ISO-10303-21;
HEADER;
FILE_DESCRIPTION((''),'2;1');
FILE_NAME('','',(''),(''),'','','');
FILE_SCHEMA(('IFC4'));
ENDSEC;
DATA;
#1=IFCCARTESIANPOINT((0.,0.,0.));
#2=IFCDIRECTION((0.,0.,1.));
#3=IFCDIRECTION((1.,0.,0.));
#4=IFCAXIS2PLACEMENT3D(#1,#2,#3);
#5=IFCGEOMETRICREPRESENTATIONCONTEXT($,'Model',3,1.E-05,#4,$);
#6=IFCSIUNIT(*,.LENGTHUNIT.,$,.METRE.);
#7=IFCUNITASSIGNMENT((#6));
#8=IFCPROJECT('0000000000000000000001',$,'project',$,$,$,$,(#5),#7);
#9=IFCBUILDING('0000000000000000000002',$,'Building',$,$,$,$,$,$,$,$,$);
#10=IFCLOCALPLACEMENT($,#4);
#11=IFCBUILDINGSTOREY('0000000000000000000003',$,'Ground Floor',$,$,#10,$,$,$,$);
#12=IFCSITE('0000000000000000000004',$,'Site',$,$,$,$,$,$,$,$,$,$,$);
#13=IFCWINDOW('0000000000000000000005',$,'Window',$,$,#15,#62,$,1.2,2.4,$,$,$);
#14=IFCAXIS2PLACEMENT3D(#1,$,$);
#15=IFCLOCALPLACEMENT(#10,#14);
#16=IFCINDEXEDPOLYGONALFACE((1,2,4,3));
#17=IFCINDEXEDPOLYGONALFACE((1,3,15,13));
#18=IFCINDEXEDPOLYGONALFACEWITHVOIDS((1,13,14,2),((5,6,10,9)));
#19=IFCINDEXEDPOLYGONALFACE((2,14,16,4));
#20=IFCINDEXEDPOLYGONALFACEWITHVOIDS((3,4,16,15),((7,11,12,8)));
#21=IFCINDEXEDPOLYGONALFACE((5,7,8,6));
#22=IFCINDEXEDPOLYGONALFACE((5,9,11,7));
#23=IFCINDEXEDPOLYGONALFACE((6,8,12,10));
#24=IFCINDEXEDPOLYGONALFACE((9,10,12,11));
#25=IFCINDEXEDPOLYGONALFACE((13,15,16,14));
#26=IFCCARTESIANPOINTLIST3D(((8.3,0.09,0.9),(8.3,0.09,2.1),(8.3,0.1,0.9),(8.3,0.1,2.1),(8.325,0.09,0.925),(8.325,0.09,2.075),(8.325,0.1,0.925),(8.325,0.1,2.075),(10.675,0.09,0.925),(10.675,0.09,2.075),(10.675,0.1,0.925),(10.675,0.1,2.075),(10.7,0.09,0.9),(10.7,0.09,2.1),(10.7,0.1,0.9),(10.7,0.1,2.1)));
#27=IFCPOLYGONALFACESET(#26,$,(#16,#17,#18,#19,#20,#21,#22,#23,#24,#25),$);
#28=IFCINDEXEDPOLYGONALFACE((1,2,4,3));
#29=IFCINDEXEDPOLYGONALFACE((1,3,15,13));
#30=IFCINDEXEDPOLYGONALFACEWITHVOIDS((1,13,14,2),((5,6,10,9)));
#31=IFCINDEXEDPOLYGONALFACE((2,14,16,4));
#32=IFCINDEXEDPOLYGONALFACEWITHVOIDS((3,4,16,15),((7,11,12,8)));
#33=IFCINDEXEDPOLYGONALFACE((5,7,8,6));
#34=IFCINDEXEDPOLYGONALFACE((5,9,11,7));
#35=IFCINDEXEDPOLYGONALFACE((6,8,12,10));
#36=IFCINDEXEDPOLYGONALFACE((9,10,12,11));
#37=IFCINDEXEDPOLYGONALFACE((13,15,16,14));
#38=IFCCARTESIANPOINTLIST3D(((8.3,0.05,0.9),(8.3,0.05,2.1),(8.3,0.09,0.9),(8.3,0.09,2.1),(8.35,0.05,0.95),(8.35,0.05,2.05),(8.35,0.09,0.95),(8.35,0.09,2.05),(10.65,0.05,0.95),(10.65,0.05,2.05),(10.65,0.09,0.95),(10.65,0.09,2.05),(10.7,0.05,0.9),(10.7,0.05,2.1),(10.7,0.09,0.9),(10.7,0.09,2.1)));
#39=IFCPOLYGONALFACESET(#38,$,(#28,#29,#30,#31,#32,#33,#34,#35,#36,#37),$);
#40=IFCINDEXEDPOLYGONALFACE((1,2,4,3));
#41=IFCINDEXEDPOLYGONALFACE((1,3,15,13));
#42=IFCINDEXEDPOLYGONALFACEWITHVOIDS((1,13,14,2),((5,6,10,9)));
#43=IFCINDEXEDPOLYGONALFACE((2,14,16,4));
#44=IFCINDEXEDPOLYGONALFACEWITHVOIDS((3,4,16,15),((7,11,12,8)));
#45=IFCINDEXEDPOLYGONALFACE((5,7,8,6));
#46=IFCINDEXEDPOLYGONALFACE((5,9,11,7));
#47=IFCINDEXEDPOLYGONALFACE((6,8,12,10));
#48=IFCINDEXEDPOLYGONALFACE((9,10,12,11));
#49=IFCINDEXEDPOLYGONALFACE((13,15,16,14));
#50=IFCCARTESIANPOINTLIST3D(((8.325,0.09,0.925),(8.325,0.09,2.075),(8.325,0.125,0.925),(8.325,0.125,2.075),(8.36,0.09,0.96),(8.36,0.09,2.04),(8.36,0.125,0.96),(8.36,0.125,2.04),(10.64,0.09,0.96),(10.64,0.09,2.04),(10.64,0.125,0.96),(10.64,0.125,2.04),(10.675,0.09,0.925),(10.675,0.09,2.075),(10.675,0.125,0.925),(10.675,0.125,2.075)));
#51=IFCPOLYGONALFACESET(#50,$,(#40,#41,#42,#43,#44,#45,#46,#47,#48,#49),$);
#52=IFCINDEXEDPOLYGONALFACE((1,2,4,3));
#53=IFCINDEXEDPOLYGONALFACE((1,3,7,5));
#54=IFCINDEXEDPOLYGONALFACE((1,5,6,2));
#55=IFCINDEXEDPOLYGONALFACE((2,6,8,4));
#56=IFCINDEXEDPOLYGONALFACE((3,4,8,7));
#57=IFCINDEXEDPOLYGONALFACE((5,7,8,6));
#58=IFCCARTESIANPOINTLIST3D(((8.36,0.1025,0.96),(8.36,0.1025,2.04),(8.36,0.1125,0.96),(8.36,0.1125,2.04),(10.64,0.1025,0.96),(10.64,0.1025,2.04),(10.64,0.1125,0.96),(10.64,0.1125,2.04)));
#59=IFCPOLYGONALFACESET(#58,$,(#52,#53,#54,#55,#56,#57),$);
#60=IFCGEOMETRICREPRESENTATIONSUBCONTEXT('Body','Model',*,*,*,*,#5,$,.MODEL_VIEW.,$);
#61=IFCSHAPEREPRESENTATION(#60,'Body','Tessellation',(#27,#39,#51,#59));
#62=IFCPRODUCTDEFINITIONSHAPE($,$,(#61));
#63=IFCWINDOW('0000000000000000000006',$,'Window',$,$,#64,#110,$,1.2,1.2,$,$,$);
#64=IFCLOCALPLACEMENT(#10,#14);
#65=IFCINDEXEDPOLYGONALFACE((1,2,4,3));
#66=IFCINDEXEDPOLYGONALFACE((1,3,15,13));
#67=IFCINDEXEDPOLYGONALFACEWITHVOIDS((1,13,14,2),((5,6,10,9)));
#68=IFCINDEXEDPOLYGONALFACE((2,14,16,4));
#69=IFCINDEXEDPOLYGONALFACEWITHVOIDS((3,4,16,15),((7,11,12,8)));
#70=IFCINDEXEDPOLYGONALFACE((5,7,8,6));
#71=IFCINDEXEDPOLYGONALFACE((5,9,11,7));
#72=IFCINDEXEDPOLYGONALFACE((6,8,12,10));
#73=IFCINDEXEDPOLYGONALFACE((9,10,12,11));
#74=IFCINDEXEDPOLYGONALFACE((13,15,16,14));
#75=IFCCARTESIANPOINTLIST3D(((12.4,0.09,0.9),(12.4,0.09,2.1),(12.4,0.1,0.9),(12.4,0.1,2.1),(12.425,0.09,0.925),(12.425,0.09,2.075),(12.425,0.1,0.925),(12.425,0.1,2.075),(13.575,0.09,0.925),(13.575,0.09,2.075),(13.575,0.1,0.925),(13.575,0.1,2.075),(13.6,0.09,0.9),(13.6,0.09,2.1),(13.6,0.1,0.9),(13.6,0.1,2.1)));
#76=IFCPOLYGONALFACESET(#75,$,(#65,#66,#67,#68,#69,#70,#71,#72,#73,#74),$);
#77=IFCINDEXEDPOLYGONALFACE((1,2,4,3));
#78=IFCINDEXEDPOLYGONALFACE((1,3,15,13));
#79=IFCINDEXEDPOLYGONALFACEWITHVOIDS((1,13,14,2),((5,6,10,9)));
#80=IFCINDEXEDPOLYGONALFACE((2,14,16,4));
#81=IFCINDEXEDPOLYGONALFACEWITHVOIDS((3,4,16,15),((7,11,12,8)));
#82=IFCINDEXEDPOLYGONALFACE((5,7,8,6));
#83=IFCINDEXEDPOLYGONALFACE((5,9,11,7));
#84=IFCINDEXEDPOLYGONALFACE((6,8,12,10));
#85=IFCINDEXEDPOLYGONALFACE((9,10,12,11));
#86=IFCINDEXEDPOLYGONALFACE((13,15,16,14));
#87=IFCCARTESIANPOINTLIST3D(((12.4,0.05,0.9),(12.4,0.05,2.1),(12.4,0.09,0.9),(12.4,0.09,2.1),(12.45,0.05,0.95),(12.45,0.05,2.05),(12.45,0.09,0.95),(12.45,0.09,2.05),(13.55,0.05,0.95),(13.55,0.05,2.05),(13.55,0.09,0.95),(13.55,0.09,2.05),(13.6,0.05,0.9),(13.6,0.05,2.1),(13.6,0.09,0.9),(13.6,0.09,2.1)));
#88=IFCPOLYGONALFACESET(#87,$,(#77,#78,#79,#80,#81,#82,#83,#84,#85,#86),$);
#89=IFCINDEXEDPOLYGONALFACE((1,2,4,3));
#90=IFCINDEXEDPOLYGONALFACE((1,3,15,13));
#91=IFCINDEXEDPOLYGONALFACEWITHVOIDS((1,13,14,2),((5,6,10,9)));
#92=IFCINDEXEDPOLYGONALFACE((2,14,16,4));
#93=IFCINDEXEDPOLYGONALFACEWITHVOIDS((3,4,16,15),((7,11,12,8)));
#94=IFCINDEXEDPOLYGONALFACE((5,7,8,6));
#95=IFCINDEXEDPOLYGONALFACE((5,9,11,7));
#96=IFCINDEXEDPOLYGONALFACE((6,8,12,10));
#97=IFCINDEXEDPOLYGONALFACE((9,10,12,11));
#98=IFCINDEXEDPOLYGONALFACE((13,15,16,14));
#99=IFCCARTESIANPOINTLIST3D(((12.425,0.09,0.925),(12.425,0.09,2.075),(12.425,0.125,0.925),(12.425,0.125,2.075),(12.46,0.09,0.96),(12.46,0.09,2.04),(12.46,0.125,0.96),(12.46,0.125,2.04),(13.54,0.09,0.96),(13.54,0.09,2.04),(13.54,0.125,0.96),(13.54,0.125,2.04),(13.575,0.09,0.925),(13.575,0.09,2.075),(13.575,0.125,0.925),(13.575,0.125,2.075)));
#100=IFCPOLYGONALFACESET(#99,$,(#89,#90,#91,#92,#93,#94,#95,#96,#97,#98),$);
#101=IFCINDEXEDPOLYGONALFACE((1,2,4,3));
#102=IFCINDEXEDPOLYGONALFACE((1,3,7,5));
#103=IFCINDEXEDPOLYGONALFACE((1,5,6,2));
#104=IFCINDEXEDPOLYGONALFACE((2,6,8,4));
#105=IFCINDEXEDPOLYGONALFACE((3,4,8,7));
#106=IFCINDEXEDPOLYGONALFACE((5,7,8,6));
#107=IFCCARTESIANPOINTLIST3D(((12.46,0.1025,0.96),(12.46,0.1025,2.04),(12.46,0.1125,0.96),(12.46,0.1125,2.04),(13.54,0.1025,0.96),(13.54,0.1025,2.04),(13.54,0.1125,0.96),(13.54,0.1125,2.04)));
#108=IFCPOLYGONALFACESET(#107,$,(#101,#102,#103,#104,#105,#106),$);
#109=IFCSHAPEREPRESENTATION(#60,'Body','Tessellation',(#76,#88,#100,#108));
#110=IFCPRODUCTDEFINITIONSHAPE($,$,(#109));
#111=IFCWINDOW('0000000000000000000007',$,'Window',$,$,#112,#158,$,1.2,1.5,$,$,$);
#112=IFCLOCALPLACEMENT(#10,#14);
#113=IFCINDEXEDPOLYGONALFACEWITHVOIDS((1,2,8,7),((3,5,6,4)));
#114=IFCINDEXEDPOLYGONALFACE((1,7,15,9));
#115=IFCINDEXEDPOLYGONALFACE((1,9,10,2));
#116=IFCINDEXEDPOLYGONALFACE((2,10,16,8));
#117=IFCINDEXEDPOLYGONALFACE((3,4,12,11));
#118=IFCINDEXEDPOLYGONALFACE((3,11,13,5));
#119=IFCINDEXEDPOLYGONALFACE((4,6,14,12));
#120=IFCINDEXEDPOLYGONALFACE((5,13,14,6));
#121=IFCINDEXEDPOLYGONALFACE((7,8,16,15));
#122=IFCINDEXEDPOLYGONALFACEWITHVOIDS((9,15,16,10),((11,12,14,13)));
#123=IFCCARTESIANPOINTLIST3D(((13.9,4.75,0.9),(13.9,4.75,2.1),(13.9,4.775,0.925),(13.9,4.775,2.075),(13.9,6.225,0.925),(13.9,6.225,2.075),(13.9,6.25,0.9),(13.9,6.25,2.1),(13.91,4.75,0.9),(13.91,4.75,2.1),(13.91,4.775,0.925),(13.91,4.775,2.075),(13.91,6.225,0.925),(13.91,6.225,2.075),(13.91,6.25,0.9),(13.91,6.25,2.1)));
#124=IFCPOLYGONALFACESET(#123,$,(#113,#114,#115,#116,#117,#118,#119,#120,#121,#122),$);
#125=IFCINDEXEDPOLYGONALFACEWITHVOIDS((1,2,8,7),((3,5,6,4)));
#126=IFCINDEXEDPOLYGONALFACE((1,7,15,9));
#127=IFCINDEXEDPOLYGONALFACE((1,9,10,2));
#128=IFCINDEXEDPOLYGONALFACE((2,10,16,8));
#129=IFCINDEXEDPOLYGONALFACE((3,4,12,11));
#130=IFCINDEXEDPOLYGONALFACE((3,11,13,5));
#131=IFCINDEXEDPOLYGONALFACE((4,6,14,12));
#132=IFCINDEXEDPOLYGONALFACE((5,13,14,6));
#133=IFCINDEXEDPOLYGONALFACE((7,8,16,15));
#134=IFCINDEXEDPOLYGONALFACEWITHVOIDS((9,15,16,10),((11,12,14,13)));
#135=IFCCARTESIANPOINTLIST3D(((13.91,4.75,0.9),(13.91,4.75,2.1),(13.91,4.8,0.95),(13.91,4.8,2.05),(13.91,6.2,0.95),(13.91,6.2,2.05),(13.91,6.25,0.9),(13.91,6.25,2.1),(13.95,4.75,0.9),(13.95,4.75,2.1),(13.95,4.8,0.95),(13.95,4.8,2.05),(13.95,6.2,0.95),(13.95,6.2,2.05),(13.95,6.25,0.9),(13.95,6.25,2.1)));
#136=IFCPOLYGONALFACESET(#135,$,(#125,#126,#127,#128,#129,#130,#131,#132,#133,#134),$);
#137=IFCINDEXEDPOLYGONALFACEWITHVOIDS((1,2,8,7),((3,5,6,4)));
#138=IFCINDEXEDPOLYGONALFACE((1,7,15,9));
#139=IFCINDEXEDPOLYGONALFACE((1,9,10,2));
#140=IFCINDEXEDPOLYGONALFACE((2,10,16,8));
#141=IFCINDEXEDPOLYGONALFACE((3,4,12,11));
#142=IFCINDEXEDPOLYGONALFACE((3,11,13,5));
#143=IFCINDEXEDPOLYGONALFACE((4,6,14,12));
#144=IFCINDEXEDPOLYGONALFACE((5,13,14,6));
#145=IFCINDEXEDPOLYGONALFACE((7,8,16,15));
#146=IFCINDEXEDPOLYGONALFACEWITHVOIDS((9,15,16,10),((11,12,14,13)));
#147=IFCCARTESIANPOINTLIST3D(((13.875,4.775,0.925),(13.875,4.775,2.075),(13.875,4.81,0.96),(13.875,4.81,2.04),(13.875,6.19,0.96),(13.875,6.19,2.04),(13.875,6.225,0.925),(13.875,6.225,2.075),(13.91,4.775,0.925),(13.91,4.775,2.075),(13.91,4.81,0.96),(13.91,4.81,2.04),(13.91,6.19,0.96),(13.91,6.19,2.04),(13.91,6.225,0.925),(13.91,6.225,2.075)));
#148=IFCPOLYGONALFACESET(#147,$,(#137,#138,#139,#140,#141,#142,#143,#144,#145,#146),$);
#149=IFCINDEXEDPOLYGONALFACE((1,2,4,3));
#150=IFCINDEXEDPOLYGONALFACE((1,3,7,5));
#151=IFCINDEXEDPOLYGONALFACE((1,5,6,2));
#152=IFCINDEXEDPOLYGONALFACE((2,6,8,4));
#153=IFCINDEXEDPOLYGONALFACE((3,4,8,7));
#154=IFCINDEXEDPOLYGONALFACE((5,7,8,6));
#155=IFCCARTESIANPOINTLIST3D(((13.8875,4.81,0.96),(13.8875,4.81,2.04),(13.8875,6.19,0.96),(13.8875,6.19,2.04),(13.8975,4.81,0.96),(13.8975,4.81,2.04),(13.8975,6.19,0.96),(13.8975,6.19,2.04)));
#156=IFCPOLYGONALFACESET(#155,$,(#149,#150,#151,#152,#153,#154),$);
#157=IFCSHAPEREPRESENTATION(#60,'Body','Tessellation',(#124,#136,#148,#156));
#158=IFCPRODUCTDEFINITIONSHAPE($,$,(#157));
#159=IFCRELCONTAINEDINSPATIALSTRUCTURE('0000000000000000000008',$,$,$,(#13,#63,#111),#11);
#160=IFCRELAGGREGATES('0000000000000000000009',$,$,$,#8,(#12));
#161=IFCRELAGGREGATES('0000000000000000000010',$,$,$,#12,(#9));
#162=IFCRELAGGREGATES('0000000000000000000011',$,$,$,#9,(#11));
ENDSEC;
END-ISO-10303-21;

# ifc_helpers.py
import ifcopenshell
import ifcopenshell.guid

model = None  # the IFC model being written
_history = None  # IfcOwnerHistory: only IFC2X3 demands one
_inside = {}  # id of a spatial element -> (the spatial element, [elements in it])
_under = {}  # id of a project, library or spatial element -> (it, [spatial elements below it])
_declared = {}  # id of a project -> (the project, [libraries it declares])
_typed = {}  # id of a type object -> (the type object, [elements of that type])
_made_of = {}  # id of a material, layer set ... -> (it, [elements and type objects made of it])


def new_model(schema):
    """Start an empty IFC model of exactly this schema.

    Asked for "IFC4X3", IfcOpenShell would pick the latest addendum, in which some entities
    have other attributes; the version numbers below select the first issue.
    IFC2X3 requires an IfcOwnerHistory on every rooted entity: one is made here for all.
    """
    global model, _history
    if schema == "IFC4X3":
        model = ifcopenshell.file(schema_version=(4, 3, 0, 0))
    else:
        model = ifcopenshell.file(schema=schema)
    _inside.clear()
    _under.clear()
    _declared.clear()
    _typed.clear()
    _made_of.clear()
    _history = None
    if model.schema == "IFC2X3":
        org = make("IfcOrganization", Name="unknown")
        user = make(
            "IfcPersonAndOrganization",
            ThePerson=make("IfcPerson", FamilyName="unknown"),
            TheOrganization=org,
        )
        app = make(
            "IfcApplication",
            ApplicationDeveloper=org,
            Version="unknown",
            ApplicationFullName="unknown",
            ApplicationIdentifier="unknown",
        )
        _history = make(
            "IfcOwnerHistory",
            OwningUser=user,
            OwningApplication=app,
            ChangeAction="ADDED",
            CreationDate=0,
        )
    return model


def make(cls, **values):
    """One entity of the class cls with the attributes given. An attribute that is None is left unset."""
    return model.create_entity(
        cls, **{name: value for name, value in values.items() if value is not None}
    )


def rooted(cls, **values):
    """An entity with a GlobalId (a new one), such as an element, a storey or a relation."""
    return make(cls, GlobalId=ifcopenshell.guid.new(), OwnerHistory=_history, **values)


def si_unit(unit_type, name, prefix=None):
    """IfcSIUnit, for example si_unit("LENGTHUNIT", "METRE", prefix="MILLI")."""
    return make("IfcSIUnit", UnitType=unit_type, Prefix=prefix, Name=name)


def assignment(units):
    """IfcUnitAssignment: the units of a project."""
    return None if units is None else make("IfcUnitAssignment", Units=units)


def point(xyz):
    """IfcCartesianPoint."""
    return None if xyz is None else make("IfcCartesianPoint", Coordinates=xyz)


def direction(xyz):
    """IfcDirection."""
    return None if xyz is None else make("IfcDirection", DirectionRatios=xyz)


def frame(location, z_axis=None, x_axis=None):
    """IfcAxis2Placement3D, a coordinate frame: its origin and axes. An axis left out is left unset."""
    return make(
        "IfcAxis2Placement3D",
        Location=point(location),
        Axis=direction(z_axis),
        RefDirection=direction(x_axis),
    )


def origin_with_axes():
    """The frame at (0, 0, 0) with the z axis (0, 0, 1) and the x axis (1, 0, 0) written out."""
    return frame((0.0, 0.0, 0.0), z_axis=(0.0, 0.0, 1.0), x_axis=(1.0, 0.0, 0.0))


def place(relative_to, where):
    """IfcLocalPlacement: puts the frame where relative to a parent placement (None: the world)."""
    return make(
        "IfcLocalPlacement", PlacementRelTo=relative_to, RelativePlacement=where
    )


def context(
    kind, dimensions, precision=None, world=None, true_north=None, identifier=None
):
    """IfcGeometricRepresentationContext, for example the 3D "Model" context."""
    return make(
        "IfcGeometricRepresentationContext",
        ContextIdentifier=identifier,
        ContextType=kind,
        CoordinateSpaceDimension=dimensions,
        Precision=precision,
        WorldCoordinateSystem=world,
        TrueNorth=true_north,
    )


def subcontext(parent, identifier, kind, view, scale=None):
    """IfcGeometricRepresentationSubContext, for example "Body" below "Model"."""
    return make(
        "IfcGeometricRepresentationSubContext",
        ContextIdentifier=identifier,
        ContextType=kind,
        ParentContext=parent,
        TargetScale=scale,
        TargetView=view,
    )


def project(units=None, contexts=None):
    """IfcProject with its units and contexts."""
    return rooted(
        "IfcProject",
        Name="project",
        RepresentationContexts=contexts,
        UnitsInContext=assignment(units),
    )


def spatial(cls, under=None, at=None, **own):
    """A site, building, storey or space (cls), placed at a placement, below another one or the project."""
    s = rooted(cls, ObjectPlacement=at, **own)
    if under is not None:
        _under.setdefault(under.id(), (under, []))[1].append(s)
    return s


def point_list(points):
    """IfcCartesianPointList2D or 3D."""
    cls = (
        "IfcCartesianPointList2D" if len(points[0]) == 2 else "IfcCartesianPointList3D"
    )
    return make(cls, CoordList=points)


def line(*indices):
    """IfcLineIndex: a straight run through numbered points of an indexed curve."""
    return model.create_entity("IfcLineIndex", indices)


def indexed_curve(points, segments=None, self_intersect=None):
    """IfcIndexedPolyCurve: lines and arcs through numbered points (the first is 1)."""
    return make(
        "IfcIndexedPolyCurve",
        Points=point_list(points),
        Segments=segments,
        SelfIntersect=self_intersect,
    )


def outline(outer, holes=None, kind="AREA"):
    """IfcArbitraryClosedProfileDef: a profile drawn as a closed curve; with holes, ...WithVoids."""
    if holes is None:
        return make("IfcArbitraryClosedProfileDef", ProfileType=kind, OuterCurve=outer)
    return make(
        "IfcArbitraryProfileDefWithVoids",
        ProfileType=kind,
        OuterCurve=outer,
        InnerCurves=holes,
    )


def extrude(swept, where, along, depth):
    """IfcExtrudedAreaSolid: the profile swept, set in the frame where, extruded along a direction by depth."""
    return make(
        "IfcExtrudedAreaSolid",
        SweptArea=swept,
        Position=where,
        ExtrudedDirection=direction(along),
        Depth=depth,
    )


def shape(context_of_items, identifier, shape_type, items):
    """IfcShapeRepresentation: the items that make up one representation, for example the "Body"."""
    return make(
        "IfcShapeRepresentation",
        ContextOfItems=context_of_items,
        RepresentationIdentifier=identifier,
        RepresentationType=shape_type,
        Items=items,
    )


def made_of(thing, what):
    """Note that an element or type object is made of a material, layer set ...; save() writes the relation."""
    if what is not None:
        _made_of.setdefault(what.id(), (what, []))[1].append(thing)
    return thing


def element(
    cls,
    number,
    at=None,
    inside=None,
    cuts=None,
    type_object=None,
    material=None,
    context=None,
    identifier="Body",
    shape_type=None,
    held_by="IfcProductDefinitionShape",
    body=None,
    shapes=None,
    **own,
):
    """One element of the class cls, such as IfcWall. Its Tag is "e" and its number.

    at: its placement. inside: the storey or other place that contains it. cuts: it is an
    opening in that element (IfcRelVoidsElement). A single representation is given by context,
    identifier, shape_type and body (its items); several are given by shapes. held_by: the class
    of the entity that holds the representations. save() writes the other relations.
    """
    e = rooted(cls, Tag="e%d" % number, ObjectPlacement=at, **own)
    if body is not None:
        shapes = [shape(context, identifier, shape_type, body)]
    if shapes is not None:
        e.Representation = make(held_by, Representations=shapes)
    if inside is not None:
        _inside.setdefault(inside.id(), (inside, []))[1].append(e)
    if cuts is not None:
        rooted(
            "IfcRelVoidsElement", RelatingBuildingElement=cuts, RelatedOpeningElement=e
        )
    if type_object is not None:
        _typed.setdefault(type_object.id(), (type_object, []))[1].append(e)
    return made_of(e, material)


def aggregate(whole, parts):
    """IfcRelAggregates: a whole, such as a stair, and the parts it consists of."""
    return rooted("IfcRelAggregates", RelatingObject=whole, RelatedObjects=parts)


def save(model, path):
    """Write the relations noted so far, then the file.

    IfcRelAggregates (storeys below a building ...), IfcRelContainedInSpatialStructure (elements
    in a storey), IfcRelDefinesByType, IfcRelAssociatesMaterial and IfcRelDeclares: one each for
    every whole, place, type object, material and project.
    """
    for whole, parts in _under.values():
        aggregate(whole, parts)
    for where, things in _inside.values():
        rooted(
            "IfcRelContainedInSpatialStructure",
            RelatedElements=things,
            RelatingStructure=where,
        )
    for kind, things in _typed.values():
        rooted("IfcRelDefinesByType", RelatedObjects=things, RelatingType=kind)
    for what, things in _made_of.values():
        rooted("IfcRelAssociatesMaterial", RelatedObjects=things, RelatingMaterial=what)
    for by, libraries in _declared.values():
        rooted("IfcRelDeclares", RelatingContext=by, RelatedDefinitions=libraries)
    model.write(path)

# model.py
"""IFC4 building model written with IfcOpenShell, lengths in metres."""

from ifc_helpers import new_model, si_unit, frame, origin_with_axes, place, context, subcontext, project, spatial, line, indexed_curve, outline, extrude, element, save


model = new_model("IFC4")

# Units and contexts
model_context = context("Model", 3, precision=1e-05, world=origin_with_axes())
body_context = subcontext(model_context, "Body", "Model", "MODEL_VIEW")
ifc_project = project(units=[si_unit("LENGTHUNIT", "METRE")], contexts=[model_context])

# Site, building, storey
site = spatial("IfcSite", under=ifc_project, Name="Site")
building = spatial("IfcBuilding", under=site, Name="Building")
storey_placement = place(None, origin_with_axes())
storey = spatial("IfcBuildingStorey", under=building, at=storey_placement, Name="Ground Floor")

# Windows
window_1_placement = place(storey_placement, frame((8.3, 0.0, 0.9), z_axis=(0.0, 0.0, 1.0), x_axis=(1.0, 0.0, 0.0)))
element("IfcWindow", 1, at=window_1_placement, inside=storey, Name="Window", OverallHeight=1.2, OverallWidth=2.4, context=body_context, shape_type="SweptSolid", body=[
    extrude(outline(indexed_curve([(0.0, 0.0), (2.4, 0.0), (2.4, 1.2), (0.0, 1.2)], segments=[line(1, 2, 3, 4, 1)]), holes=[indexed_curve([(0.025, 0.025), (2.375, 0.025), (2.375, 1.175), (0.025, 1.175)], segments=[line(1, 2, 3, 4, 1)])]), frame((0.0, 0.09, 0.0), z_axis=(0.0, -1.0, 0.0), x_axis=(1.0, 0.0, 0.0)), (0.0, 0.0, -1.0), 0.01),
    extrude(outline(indexed_curve([(0.0, 0.0), (2.4, 0.0), (2.4, 1.2), (0.0, 1.2)], segments=[line(1, 2, 3, 4, 1)]), holes=[indexed_curve([(0.05, 0.05), (2.35, 0.05), (2.35, 1.15), (0.05, 1.15)], segments=[line(1, 2, 3, 4, 1)])]), frame((0.0, 0.05, 0.0), z_axis=(0.0, -1.0, 0.0), x_axis=(1.0, 0.0, 0.0)), (0.0, 0.0, -1.0), 0.04),
    extrude(outline(indexed_curve([(0.0, 0.0), (2.35, 0.0), (2.35, 1.15), (0.0, 1.15)], segments=[line(1, 2, 3, 4, 1)]), holes=[indexed_curve([(0.035, 0.035), (2.315, 0.035), (2.315, 1.115), (0.035, 1.115)], segments=[line(1, 2, 3, 4, 1)])]), frame((0.025, 0.09, 0.025), z_axis=(0.0, -1.0, 0.0), x_axis=(1.0, 0.0, 0.0)), (0.0, 0.0, -1.0), 0.035),
    extrude(outline(indexed_curve([(0.035, 0.035), (2.315, 0.035), (2.315, 1.115), (0.035, 1.115)], segments=[line(1, 2, 3, 4, 1)])), frame((0.025, 0.1025, 0.025), z_axis=(0.0, -1.0, 0.0), x_axis=(1.0, 0.0, 0.0)), (0.0, 0.0, -1.0), 0.01),
])
window_2_placement = place(storey_placement, frame((12.4, 0.0, 0.9), z_axis=(0.0, 0.0, 1.0), x_axis=(1.0, 0.0, 0.0)))
element("IfcWindow", 2, at=window_2_placement, inside=storey, Name="Window", OverallHeight=1.2, OverallWidth=1.2, context=body_context, shape_type="SweptSolid", body=[
    extrude(outline(indexed_curve([(0.0, 0.0), (1.2, 0.0), (1.2, 1.2), (0.0, 1.2)], segments=[line(1, 2, 3, 4, 1)]), holes=[indexed_curve([(0.025, 0.025), (1.175, 0.025), (1.175, 1.175), (0.025, 1.175)], segments=[line(1, 2, 3, 4, 1)])]), frame((0.0, 0.09, 0.0), z_axis=(0.0, -1.0, 0.0), x_axis=(1.0, 0.0, 0.0)), (0.0, 0.0, -1.0), 0.01),
    extrude(outline(indexed_curve([(0.0, 0.0), (1.2, 0.0), (1.2, 1.2), (0.0, 1.2)], segments=[line(1, 2, 3, 4, 1)]), holes=[indexed_curve([(0.05, 0.05), (1.15, 0.05), (1.15, 1.15), (0.05, 1.15)], segments=[line(1, 2, 3, 4, 1)])]), frame((0.0, 0.05, 0.0), z_axis=(0.0, -1.0, 0.0), x_axis=(1.0, 0.0, 0.0)), (0.0, 0.0, -1.0), 0.04),
    extrude(outline(indexed_curve([(0.0, 0.0), (1.15, 0.0), (1.15, 1.15), (0.0, 1.15)], segments=[line(1, 2, 3, 4, 1)]), holes=[indexed_curve([(0.035, 0.035), (1.115, 0.035), (1.115, 1.115), (0.035, 1.115)], segments=[line(1, 2, 3, 4, 1)])]), frame((0.025, 0.09, 0.025), z_axis=(0.0, -1.0, 0.0), x_axis=(1.0, 0.0, 0.0)), (0.0, 0.0, -1.0), 0.035),
    extrude(outline(indexed_curve([(0.035, 0.035), (1.115, 0.035), (1.115, 1.115), (0.035, 1.115)], segments=[line(1, 2, 3, 4, 1)])), frame((0.025, 0.1025, 0.025), z_axis=(0.0, -1.0, 0.0), x_axis=(1.0, 0.0, 0.0)), (0.0, 0.0, -1.0), 0.01),
])
window_3_placement = place(storey_placement, frame((14.0, 4.75, 0.9), z_axis=(0.0, 0.0, 1.0), x_axis=(0.0, 1.0, 0.0)))
element("IfcWindow", 3, at=window_3_placement, inside=storey, Name="Window", OverallHeight=1.2, OverallWidth=1.5, context=body_context, shape_type="SweptSolid", body=[
    extrude(outline(indexed_curve([(0.0, 0.0), (1.5, 0.0), (1.5, 1.2), (0.0, 1.2)], segments=[line(1, 2, 3, 4, 1)]), holes=[indexed_curve([(0.025, 0.025), (1.475, 0.025), (1.475, 1.175), (0.025, 1.175)], segments=[line(1, 2, 3, 4, 1)])]), frame((0.0, 0.09, 0.0), z_axis=(0.0, -1.0, 0.0), x_axis=(1.0, 0.0, 0.0)), (0.0, 0.0, -1.0), 0.01),
    extrude(outline(indexed_curve([(0.0, 0.0), (1.5, 0.0), (1.5, 1.2), (0.0, 1.2)], segments=[line(1, 2, 3, 4, 1)]), holes=[indexed_curve([(0.05, 0.05), (1.45, 0.05), (1.45, 1.15), (0.05, 1.15)], segments=[line(1, 2, 3, 4, 1)])]), frame((0.0, 0.05, 0.0), z_axis=(0.0, -1.0, 0.0), x_axis=(1.0, 0.0, 0.0)), (0.0, 0.0, -1.0), 0.04),
    extrude(outline(indexed_curve([(0.0, 0.0), (1.45, 0.0), (1.45, 1.15), (0.0, 1.15)], segments=[line(1, 2, 3, 4, 1)]), holes=[indexed_curve([(0.035, 0.035), (1.415, 0.035), (1.415, 1.115), (0.035, 1.115)], segments=[line(1, 2, 3, 4, 1)])]), frame((0.025, 0.09, 0.025), z_axis=(0.0, -1.0, 0.0), x_axis=(1.0, 0.0, 0.0)), (0.0, 0.0, -1.0), 0.035),
    extrude(outline(indexed_curve([(0.035, 0.035), (1.415, 0.035), (1.415, 1.115), (0.035, 1.115)], segments=[line(1, 2, 3, 4, 1)])), frame((0.025, 0.1025, 0.025), z_axis=(0.0, -1.0, 0.0), x_axis=(1.0, 0.0, 0.0)), (0.0, 0.0, -1.0), 0.01),
])

save(model, "model.ifc")
